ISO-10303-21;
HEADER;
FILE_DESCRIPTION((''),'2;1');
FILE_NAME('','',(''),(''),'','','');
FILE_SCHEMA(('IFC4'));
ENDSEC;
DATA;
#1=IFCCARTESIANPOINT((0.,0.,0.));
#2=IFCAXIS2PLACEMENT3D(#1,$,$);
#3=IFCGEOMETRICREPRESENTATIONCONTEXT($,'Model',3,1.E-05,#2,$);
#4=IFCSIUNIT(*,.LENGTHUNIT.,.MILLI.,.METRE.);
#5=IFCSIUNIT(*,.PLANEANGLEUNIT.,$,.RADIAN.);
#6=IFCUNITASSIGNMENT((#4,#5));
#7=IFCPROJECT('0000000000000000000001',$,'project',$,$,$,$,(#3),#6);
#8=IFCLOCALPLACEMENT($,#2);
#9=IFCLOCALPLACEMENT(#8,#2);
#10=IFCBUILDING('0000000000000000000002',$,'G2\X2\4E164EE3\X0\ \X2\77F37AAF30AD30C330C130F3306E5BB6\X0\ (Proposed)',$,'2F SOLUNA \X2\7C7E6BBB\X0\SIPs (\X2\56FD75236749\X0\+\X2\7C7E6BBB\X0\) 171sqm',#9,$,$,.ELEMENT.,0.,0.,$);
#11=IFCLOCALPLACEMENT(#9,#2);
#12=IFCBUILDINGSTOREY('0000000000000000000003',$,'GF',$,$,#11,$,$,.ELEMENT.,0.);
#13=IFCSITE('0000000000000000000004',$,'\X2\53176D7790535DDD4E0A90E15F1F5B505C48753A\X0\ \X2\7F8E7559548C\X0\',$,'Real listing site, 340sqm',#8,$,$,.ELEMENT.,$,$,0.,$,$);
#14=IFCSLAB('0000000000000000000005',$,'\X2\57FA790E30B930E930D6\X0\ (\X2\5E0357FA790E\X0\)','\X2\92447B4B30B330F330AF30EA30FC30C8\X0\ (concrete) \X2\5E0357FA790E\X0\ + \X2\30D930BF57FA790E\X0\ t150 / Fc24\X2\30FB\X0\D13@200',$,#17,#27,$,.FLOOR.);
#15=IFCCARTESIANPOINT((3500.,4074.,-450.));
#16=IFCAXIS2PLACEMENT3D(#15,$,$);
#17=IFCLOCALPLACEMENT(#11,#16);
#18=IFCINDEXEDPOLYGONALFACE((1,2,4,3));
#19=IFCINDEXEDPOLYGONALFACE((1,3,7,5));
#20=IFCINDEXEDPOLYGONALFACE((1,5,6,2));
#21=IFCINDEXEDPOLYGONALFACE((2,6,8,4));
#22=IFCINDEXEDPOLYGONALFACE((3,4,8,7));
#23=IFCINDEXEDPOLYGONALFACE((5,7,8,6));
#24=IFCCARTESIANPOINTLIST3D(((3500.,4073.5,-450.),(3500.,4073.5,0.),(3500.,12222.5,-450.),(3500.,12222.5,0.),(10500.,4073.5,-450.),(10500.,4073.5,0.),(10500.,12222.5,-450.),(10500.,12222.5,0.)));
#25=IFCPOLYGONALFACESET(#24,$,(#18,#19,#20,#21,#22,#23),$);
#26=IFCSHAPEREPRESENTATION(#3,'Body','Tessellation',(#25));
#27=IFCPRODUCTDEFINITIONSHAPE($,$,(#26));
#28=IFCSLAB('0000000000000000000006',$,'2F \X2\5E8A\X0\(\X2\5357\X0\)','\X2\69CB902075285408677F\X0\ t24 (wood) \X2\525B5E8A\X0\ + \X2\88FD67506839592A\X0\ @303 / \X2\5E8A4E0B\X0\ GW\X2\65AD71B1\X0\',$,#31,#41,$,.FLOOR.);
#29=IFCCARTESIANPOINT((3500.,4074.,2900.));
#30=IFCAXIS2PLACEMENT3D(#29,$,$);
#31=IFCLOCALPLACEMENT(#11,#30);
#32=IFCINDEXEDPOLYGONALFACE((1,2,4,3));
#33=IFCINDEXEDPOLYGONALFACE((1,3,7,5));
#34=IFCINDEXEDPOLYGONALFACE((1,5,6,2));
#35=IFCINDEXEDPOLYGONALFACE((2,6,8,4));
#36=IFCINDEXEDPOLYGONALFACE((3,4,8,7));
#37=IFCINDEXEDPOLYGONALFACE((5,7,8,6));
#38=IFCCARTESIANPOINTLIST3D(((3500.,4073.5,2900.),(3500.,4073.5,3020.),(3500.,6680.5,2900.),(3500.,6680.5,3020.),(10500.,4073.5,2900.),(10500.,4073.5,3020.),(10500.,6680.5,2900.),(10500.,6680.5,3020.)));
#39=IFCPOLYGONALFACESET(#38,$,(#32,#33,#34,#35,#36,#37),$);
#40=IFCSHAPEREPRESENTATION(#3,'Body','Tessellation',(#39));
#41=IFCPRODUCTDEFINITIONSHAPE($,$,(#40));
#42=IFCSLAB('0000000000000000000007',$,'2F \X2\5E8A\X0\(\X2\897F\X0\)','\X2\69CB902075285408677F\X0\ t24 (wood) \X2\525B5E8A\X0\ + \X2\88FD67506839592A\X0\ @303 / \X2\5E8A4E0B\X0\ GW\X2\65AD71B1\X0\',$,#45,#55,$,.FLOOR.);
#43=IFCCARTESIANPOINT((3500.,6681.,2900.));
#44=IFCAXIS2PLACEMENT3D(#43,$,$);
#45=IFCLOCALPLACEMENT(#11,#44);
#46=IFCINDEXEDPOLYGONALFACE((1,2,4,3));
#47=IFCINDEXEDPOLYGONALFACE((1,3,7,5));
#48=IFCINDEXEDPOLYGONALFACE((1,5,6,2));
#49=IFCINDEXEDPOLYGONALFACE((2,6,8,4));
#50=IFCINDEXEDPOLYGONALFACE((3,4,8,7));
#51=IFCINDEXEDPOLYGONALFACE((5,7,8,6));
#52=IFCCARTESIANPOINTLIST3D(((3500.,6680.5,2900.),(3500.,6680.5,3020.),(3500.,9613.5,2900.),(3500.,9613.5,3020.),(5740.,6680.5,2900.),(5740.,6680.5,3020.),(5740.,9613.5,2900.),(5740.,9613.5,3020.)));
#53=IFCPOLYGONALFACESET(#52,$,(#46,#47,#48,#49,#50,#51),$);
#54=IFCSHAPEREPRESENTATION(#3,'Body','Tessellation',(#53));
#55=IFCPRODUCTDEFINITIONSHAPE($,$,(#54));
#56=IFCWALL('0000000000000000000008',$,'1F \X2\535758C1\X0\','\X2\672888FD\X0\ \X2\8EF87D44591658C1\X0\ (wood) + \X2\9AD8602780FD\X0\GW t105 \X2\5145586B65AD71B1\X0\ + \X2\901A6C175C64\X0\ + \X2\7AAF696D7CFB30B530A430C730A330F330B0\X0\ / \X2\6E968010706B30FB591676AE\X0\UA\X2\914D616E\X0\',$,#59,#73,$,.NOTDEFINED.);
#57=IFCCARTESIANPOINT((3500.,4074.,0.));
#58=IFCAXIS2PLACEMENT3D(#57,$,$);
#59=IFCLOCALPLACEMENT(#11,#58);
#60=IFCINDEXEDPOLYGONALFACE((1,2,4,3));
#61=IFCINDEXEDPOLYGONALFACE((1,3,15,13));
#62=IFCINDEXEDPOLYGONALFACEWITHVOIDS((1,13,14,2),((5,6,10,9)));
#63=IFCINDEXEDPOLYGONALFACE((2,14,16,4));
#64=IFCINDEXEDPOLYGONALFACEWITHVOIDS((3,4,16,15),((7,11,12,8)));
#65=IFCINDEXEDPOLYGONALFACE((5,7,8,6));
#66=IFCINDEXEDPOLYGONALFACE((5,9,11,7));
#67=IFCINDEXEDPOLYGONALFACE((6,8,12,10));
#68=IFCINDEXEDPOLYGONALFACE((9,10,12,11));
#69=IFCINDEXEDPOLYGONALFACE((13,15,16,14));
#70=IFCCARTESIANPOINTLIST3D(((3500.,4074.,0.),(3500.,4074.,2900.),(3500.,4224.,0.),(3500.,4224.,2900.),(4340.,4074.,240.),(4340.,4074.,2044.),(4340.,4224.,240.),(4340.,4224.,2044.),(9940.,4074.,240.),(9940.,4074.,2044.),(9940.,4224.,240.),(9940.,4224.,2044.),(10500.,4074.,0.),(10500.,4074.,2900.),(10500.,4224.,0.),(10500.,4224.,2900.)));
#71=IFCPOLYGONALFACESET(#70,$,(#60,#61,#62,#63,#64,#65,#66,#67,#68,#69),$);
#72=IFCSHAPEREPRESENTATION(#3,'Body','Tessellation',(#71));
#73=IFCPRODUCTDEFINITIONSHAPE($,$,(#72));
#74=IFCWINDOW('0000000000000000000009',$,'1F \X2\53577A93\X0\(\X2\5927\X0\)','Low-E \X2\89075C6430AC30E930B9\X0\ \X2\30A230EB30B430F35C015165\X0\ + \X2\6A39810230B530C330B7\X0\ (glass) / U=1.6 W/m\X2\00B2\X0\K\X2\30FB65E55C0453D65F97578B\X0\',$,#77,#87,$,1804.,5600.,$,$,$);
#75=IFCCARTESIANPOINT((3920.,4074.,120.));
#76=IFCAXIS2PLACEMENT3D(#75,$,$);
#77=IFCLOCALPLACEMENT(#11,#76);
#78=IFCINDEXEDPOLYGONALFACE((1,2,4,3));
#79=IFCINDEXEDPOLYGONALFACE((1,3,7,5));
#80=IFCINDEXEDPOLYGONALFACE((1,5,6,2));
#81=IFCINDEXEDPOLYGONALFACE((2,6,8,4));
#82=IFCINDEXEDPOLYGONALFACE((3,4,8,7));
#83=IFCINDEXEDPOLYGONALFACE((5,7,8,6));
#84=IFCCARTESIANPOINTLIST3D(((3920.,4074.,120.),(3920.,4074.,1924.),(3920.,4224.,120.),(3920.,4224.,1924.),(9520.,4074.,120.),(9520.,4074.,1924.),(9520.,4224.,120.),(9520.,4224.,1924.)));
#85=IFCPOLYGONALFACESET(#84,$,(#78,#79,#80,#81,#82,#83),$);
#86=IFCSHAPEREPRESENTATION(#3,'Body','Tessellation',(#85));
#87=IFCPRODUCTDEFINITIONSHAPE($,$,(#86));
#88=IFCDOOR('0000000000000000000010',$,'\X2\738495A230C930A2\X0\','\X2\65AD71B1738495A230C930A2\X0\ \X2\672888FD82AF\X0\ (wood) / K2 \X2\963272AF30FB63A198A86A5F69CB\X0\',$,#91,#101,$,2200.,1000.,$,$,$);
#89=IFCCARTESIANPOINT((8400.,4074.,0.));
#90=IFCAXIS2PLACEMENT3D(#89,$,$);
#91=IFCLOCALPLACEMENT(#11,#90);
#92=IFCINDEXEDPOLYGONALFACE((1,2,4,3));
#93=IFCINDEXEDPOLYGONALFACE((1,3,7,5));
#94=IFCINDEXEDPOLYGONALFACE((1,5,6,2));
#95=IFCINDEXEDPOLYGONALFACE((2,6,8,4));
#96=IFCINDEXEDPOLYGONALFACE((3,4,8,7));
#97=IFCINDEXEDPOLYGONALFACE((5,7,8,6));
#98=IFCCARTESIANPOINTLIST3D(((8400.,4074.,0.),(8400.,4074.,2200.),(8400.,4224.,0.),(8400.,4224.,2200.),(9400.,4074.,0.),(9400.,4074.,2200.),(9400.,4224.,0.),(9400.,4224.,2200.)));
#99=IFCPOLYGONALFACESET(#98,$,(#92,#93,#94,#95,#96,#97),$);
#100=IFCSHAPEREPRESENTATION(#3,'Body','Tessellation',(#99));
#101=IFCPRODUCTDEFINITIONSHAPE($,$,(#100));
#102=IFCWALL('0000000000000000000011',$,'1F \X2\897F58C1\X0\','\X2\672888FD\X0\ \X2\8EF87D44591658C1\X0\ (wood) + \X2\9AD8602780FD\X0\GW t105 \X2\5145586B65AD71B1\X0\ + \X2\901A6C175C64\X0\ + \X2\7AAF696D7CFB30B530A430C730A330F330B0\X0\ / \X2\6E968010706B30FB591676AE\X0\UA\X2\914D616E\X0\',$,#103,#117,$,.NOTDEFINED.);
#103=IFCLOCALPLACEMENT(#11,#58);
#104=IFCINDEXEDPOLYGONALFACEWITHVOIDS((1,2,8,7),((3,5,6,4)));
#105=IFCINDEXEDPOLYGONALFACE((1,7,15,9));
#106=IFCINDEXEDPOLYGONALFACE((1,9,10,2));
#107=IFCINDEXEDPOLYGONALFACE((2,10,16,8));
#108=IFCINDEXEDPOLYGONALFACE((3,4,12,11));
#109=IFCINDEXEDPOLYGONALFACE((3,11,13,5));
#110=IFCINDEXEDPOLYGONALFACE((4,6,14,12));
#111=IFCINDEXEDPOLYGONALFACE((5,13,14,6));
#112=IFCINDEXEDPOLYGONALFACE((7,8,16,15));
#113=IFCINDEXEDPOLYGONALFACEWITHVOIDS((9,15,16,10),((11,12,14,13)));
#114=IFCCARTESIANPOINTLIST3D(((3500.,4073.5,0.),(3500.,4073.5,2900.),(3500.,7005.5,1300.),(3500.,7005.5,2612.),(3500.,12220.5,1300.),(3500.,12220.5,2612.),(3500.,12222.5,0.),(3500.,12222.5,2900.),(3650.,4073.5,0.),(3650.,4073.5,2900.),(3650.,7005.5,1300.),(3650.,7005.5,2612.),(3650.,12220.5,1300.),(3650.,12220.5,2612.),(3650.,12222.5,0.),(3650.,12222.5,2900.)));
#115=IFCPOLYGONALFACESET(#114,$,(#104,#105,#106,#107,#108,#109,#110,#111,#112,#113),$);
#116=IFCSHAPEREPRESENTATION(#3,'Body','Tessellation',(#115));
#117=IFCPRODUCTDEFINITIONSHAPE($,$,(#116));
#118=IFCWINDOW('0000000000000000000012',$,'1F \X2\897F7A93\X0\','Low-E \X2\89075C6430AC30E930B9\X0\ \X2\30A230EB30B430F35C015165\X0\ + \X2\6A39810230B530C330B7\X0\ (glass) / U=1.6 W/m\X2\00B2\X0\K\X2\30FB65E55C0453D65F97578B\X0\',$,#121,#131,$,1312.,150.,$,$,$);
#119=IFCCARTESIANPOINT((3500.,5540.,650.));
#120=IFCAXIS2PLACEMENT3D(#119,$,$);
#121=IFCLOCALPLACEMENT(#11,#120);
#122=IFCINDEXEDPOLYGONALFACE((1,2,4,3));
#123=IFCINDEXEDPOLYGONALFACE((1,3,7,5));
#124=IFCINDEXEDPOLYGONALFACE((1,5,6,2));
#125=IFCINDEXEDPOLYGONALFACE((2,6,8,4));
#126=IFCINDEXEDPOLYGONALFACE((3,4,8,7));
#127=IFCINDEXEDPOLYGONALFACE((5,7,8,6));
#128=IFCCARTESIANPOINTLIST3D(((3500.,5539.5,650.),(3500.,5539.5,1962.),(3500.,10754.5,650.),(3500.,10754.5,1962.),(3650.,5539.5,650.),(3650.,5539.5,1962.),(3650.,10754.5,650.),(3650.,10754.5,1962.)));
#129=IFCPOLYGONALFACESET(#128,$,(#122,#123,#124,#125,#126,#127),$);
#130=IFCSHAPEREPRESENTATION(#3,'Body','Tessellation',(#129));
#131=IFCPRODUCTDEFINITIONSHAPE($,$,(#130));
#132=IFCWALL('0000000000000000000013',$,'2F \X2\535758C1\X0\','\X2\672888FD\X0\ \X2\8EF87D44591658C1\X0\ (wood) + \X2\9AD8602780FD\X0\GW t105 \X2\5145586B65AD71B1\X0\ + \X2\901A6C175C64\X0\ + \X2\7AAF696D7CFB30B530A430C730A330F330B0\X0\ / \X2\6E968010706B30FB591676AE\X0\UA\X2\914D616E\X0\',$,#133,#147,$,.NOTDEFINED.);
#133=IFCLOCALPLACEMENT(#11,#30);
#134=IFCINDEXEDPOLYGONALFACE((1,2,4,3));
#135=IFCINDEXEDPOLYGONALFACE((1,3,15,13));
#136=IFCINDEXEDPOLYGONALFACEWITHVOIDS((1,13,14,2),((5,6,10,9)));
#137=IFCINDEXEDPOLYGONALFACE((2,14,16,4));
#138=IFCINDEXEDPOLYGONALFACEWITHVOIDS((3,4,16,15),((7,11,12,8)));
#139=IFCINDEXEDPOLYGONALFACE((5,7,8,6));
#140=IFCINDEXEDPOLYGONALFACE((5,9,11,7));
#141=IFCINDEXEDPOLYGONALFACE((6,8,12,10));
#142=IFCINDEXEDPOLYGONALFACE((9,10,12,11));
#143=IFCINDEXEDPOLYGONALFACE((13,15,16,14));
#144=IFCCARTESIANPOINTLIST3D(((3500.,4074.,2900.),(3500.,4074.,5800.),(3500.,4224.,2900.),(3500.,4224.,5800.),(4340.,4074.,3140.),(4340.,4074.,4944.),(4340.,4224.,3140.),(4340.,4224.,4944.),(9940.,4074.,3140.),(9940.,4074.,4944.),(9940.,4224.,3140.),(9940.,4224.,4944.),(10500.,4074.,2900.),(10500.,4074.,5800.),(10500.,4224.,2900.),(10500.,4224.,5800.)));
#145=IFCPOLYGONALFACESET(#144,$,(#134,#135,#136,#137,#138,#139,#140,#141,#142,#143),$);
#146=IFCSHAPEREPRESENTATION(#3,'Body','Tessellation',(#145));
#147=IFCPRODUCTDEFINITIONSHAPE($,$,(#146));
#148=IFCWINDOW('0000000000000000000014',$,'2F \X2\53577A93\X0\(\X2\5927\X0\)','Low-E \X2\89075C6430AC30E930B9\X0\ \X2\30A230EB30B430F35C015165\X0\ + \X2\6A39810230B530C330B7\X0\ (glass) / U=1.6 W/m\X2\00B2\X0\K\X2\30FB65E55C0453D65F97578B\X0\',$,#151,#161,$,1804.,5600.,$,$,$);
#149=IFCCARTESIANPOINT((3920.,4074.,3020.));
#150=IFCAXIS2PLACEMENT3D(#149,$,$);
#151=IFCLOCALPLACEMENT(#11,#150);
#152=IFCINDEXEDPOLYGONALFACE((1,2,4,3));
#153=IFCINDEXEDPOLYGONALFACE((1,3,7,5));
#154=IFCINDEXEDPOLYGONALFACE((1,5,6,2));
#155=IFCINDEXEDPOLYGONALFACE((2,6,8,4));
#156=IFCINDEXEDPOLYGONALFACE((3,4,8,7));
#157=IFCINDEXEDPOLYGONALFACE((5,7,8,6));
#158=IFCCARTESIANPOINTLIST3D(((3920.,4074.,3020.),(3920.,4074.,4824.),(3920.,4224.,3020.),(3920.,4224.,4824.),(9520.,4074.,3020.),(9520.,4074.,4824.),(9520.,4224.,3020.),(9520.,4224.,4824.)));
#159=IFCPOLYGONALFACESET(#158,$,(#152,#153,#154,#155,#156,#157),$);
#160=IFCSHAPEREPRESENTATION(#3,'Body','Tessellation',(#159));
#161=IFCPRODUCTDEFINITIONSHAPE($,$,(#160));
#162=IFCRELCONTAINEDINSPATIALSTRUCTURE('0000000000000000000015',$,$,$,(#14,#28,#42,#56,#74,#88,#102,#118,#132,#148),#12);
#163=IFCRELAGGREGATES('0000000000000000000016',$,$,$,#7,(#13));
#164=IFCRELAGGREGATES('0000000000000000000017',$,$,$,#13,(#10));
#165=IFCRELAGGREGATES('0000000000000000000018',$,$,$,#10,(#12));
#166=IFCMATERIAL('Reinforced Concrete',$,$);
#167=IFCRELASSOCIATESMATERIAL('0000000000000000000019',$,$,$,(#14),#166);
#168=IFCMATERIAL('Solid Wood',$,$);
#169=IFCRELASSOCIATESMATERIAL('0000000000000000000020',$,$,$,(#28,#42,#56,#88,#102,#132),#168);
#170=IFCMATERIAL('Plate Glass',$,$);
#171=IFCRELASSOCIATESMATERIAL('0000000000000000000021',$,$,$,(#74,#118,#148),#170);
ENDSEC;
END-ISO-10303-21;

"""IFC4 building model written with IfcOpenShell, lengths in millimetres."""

from ifc_helpers import new_model, si_unit, frame, frame_2d, origin, place, context, project, spatial, rectangle, extrude, material, element, fill, save


model = new_model("IFC4")

# Units and contexts
model_context = context("Model", 3, precision=1e-05, world=origin())
ifc_project = project(units=[si_unit("LENGTHUNIT", "METRE", prefix="MILLI"), si_unit("PLANEANGLEUNIT", "RADIAN")], contexts=[model_context])

# Site, building, storey
site_placement = place(None, origin())
site = spatial("IfcSite", under=ifc_project, at=site_placement, Name="北海道川上郡弟子屈町 美留和", ObjectType="Real listing site, 340sqm", CompositionType="ELEMENT", RefElevation=0.0)
building_placement = place(site_placement, origin())
building = spatial("IfcBuilding", under=site, at=building_placement, Name="G2世代 石窯キッチンの家 (Proposed)", ObjectType="2F SOLUNA 籾殻SIPs (国産杉+籾殻) 171sqm", CompositionType="ELEMENT", ElevationOfRefHeight=0.0, ElevationOfTerrain=0.0)
storey_placement = place(building_placement, origin())
storey = spatial("IfcBuildingStorey", under=building, at=storey_placement, Name="GF", CompositionType="ELEMENT", Elevation=0.0)

# Slabs
ifc_material_1 = material(Name="Reinforced Concrete")
slab_1_placement = place(storey_placement, frame((3500.0, 4074.0, -450.0)))
element("IfcSlab", 1, at=slab_1_placement, inside=storey, material=ifc_material_1, Name="基礎スラブ (布基礎)", Description="鉄筋コンクリート (concrete) 布基礎 + ベタ基礎 t150 / Fc24・D13@200", PredefinedType="FLOOR", context=model_context, shape_type="SweptSolid", body=[
    extrude(rectangle(XDim=7000.0, YDim=8149.0, at=frame_2d((3500.0, 4074.0))), frame((3500.0, 4074.0, -450.0)), (0.0, 0.0, 1.0), 450.0),
])
ifc_material_2 = material(Name="Solid Wood")
slab_2_placement = place(storey_placement, frame((3500.0, 4074.0, 2900.0)))
element("IfcSlab", 2, at=slab_2_placement, inside=storey, material=ifc_material_2, Name="2F 床(南)", Description="構造用合板 t24 (wood) 剛床 + 製材根太 @303 / 床下 GW断熱", PredefinedType="FLOOR", context=model_context, shape_type="SweptSolid", body=[
    extrude(rectangle(XDim=7000.0, YDim=2607.0, at=frame_2d((3500.0, 1303.0))), frame((3500.0, 4074.0, 2900.0)), (0.0, 0.0, 1.0), 120.0),
])
slab_3_placement = place(storey_placement, frame((3500.0, 6681.0, 2900.0)))
element("IfcSlab", 3, at=slab_3_placement, inside=storey, material=ifc_material_2, Name="2F 床(西)", Description="構造用合板 t24 (wood) 剛床 + 製材根太 @303 / 床下 GW断熱", PredefinedType="FLOOR", context=model_context, shape_type="SweptSolid", body=[
    extrude(rectangle(XDim=2240.0, YDim=2933.0, at=frame_2d((1120.0, 1466.0))), frame((3500.0, 6681.0, 2900.0)), (0.0, 0.0, 1.0), 120.0),
])

# Wall, openings, window, door
wall_1_placement = place(storey_placement, frame((3500.0, 4074.0, 0.0)))
wall_1 = element("IfcWall", 4, at=wall_1_placement, inside=storey, material=ifc_material_2, Name="1F 南壁", Description="木製 軸組外壁 (wood) + 高性能GW t105 充填断熱 + 通気層 + 窯業系サイディング / 準耐火・外皮UA配慮", PredefinedType="NOTDEFINED", context=model_context, shape_type="SweptSolid", body=[
    extrude(rectangle(XDim=7000.0, YDim=150.0, at=frame_2d((3500.0, 75.0))), frame((3500.0, 4074.0, 0.0)), (0.0, 0.0, 1.0), 2900.0),
])
opening_1_placement = place(storey_placement, frame((3920.0, 4074.0, 120.0)))
opening_1 = element("IfcOpeningElement", 5, at=opening_1_placement, cuts=wall_1, PredefinedType="NOTDEFINED", context=model_context, shape_type="SweptSolid", body=[
    extrude(rectangle(XDim=5600.0, YDim=150.0, at=frame_2d((2800.0, 75.0))), frame((3920.0, 4074.0, 120.0)), (0.0, 0.0, 1.0), 1804.0),
])
opening_2_placement = place(storey_placement, frame((8400.0, 4074.0, 0.0)))
opening_2 = element("IfcOpeningElement", 6, at=opening_2_placement, cuts=wall_1, PredefinedType="NOTDEFINED", context=model_context, shape_type="SweptSolid", body=[
    extrude(rectangle(XDim=1000.0, YDim=150.0, at=frame_2d((500.0, 75.0))), frame((8400.0, 4074.0, 0.0)), (0.0, 0.0, 1.0), 2200.0),
])
ifc_material_3 = material(Name="Plate Glass")
window_1_placement = place(storey_placement, frame((3920.0, 4074.0, 120.0)))
window_1 = element("IfcWindow", 7, at=window_1_placement, inside=storey, material=ifc_material_3, Name="1F 南窓(大)", Description="Low-E 複層ガラス アルゴン封入 + 樹脂サッシ (glass) / U=1.6 W/m²K・日射取得型", OverallHeight=1804.0, OverallWidth=5600.0, context=model_context, shape_type="SweptSolid", body=[
    extrude(rectangle(XDim=5600.0, YDim=150.0, at=frame_2d((2800.0, 75.0))), frame((3920.0, 4074.0, 120.0)), (0.0, 0.0, 1.0), 1804.0),
])
fill(opening_1, window_1)
door_placement = place(storey_placement, frame((8400.0, 4074.0, 0.0)))
door = element("IfcDoor", 8, at=door_placement, inside=storey, material=ifc_material_2, Name="玄関ドア", Description="断熱玄関ドア 木製芯 (wood) / K2 防犯・採風機構", OverallHeight=2200.0, OverallWidth=1000.0, context=model_context, shape_type="SweptSolid", body=[
    extrude(rectangle(XDim=1000.0, YDim=150.0, at=frame_2d((500.0, 75.0))), frame((8400.0, 4074.0, 0.0)), (0.0, 0.0, 1.0), 2200.0),
])
fill(opening_2, door)

# Walls, openings, windows
wall_2_placement = place(storey_placement, frame((3500.0, 4074.0, 0.0)))
wall_2 = element("IfcWall", 9, at=wall_2_placement, inside=storey, material=ifc_material_2, Name="1F 西壁", Description="木製 軸組外壁 (wood) + 高性能GW t105 充填断熱 + 通気層 + 窯業系サイディング / 準耐火・外皮UA配慮", PredefinedType="NOTDEFINED", context=model_context, shape_type="SweptSolid", body=[
    extrude(rectangle(XDim=150.0, YDim=8149.0, at=frame_2d((75.0, 4074.0))), frame((3500.0, 4074.0, 0.0)), (0.0, 0.0, 1.0), 2900.0),
])
opening_3_placement = place(storey_placement, frame((3500.0, 5540.0, 650.0)))
opening_3 = element("IfcOpeningElement", 10, at=opening_3_placement, cuts=wall_2, PredefinedType="NOTDEFINED", context=model_context, shape_type="SweptSolid", body=[
    extrude(rectangle(XDim=150.0, YDim=5215.0, at=frame_2d((75.0, 2607.0))), frame((3500.0, 5540.0, 650.0)), (0.0, 0.0, 1.0), 1312.0),
])
window_2_placement = place(storey_placement, frame((3500.0, 5540.0, 650.0)))
window_2 = element("IfcWindow", 11, at=window_2_placement, inside=storey, material=ifc_material_3, Name="1F 西窓", Description="Low-E 複層ガラス アルゴン封入 + 樹脂サッシ (glass) / U=1.6 W/m²K・日射取得型", OverallHeight=1312.0, OverallWidth=150.0, context=model_context, shape_type="SweptSolid", body=[
    extrude(rectangle(XDim=150.0, YDim=5215.0, at=frame_2d((75.0, 2607.0))), frame((3500.0, 5540.0, 650.0)), (0.0, 0.0, 1.0), 1312.0),
])
fill(opening_3, window_2)
wall_3_placement = place(storey_placement, frame((3500.0, 4074.0, 2900.0)))
wall_3 = element("IfcWall", 12, at=wall_3_placement, inside=storey, material=ifc_material_2, Name="2F 南壁", Description="木製 軸組外壁 (wood) + 高性能GW t105 充填断熱 + 通気層 + 窯業系サイディング / 準耐火・外皮UA配慮", PredefinedType="NOTDEFINED", context=model_context, shape_type="SweptSolid", body=[
    extrude(rectangle(XDim=7000.0, YDim=150.0, at=frame_2d((3500.0, 75.0))), frame((3500.0, 4074.0, 2900.0)), (0.0, 0.0, 1.0), 2900.0),
])
opening_4_placement = place(storey_placement, frame((3920.0, 4074.0, 3020.0)))
opening_4 = element("IfcOpeningElement", 13, at=opening_4_placement, cuts=wall_3, PredefinedType="NOTDEFINED", context=model_context, shape_type="SweptSolid", body=[
    extrude(rectangle(XDim=5600.0, YDim=150.0, at=frame_2d((2800.0, 75.0))), frame((3920.0, 4074.0, 3020.0)), (0.0, 0.0, 1.0), 1804.0),
])
window_3_placement = place(storey_placement, frame((3920.0, 4074.0, 3020.0)))
window_3 = element("IfcWindow", 14, at=window_3_placement, inside=storey, material=ifc_material_3, Name="2F 南窓(大)", Description="Low-E 複層ガラス アルゴン封入 + 樹脂サッシ (glass) / U=1.6 W/m²K・日射取得型", OverallHeight=1804.0, OverallWidth=5600.0, context=model_context, shape_type="SweptSolid", body=[
    extrude(rectangle(XDim=5600.0, YDim=150.0, at=frame_2d((2800.0, 75.0))), frame((3920.0, 4074.0, 3020.0)), (0.0, 0.0, 1.0), 1804.0),
])
fill(opening_4, window_3)

save(model, "model.ifc")
